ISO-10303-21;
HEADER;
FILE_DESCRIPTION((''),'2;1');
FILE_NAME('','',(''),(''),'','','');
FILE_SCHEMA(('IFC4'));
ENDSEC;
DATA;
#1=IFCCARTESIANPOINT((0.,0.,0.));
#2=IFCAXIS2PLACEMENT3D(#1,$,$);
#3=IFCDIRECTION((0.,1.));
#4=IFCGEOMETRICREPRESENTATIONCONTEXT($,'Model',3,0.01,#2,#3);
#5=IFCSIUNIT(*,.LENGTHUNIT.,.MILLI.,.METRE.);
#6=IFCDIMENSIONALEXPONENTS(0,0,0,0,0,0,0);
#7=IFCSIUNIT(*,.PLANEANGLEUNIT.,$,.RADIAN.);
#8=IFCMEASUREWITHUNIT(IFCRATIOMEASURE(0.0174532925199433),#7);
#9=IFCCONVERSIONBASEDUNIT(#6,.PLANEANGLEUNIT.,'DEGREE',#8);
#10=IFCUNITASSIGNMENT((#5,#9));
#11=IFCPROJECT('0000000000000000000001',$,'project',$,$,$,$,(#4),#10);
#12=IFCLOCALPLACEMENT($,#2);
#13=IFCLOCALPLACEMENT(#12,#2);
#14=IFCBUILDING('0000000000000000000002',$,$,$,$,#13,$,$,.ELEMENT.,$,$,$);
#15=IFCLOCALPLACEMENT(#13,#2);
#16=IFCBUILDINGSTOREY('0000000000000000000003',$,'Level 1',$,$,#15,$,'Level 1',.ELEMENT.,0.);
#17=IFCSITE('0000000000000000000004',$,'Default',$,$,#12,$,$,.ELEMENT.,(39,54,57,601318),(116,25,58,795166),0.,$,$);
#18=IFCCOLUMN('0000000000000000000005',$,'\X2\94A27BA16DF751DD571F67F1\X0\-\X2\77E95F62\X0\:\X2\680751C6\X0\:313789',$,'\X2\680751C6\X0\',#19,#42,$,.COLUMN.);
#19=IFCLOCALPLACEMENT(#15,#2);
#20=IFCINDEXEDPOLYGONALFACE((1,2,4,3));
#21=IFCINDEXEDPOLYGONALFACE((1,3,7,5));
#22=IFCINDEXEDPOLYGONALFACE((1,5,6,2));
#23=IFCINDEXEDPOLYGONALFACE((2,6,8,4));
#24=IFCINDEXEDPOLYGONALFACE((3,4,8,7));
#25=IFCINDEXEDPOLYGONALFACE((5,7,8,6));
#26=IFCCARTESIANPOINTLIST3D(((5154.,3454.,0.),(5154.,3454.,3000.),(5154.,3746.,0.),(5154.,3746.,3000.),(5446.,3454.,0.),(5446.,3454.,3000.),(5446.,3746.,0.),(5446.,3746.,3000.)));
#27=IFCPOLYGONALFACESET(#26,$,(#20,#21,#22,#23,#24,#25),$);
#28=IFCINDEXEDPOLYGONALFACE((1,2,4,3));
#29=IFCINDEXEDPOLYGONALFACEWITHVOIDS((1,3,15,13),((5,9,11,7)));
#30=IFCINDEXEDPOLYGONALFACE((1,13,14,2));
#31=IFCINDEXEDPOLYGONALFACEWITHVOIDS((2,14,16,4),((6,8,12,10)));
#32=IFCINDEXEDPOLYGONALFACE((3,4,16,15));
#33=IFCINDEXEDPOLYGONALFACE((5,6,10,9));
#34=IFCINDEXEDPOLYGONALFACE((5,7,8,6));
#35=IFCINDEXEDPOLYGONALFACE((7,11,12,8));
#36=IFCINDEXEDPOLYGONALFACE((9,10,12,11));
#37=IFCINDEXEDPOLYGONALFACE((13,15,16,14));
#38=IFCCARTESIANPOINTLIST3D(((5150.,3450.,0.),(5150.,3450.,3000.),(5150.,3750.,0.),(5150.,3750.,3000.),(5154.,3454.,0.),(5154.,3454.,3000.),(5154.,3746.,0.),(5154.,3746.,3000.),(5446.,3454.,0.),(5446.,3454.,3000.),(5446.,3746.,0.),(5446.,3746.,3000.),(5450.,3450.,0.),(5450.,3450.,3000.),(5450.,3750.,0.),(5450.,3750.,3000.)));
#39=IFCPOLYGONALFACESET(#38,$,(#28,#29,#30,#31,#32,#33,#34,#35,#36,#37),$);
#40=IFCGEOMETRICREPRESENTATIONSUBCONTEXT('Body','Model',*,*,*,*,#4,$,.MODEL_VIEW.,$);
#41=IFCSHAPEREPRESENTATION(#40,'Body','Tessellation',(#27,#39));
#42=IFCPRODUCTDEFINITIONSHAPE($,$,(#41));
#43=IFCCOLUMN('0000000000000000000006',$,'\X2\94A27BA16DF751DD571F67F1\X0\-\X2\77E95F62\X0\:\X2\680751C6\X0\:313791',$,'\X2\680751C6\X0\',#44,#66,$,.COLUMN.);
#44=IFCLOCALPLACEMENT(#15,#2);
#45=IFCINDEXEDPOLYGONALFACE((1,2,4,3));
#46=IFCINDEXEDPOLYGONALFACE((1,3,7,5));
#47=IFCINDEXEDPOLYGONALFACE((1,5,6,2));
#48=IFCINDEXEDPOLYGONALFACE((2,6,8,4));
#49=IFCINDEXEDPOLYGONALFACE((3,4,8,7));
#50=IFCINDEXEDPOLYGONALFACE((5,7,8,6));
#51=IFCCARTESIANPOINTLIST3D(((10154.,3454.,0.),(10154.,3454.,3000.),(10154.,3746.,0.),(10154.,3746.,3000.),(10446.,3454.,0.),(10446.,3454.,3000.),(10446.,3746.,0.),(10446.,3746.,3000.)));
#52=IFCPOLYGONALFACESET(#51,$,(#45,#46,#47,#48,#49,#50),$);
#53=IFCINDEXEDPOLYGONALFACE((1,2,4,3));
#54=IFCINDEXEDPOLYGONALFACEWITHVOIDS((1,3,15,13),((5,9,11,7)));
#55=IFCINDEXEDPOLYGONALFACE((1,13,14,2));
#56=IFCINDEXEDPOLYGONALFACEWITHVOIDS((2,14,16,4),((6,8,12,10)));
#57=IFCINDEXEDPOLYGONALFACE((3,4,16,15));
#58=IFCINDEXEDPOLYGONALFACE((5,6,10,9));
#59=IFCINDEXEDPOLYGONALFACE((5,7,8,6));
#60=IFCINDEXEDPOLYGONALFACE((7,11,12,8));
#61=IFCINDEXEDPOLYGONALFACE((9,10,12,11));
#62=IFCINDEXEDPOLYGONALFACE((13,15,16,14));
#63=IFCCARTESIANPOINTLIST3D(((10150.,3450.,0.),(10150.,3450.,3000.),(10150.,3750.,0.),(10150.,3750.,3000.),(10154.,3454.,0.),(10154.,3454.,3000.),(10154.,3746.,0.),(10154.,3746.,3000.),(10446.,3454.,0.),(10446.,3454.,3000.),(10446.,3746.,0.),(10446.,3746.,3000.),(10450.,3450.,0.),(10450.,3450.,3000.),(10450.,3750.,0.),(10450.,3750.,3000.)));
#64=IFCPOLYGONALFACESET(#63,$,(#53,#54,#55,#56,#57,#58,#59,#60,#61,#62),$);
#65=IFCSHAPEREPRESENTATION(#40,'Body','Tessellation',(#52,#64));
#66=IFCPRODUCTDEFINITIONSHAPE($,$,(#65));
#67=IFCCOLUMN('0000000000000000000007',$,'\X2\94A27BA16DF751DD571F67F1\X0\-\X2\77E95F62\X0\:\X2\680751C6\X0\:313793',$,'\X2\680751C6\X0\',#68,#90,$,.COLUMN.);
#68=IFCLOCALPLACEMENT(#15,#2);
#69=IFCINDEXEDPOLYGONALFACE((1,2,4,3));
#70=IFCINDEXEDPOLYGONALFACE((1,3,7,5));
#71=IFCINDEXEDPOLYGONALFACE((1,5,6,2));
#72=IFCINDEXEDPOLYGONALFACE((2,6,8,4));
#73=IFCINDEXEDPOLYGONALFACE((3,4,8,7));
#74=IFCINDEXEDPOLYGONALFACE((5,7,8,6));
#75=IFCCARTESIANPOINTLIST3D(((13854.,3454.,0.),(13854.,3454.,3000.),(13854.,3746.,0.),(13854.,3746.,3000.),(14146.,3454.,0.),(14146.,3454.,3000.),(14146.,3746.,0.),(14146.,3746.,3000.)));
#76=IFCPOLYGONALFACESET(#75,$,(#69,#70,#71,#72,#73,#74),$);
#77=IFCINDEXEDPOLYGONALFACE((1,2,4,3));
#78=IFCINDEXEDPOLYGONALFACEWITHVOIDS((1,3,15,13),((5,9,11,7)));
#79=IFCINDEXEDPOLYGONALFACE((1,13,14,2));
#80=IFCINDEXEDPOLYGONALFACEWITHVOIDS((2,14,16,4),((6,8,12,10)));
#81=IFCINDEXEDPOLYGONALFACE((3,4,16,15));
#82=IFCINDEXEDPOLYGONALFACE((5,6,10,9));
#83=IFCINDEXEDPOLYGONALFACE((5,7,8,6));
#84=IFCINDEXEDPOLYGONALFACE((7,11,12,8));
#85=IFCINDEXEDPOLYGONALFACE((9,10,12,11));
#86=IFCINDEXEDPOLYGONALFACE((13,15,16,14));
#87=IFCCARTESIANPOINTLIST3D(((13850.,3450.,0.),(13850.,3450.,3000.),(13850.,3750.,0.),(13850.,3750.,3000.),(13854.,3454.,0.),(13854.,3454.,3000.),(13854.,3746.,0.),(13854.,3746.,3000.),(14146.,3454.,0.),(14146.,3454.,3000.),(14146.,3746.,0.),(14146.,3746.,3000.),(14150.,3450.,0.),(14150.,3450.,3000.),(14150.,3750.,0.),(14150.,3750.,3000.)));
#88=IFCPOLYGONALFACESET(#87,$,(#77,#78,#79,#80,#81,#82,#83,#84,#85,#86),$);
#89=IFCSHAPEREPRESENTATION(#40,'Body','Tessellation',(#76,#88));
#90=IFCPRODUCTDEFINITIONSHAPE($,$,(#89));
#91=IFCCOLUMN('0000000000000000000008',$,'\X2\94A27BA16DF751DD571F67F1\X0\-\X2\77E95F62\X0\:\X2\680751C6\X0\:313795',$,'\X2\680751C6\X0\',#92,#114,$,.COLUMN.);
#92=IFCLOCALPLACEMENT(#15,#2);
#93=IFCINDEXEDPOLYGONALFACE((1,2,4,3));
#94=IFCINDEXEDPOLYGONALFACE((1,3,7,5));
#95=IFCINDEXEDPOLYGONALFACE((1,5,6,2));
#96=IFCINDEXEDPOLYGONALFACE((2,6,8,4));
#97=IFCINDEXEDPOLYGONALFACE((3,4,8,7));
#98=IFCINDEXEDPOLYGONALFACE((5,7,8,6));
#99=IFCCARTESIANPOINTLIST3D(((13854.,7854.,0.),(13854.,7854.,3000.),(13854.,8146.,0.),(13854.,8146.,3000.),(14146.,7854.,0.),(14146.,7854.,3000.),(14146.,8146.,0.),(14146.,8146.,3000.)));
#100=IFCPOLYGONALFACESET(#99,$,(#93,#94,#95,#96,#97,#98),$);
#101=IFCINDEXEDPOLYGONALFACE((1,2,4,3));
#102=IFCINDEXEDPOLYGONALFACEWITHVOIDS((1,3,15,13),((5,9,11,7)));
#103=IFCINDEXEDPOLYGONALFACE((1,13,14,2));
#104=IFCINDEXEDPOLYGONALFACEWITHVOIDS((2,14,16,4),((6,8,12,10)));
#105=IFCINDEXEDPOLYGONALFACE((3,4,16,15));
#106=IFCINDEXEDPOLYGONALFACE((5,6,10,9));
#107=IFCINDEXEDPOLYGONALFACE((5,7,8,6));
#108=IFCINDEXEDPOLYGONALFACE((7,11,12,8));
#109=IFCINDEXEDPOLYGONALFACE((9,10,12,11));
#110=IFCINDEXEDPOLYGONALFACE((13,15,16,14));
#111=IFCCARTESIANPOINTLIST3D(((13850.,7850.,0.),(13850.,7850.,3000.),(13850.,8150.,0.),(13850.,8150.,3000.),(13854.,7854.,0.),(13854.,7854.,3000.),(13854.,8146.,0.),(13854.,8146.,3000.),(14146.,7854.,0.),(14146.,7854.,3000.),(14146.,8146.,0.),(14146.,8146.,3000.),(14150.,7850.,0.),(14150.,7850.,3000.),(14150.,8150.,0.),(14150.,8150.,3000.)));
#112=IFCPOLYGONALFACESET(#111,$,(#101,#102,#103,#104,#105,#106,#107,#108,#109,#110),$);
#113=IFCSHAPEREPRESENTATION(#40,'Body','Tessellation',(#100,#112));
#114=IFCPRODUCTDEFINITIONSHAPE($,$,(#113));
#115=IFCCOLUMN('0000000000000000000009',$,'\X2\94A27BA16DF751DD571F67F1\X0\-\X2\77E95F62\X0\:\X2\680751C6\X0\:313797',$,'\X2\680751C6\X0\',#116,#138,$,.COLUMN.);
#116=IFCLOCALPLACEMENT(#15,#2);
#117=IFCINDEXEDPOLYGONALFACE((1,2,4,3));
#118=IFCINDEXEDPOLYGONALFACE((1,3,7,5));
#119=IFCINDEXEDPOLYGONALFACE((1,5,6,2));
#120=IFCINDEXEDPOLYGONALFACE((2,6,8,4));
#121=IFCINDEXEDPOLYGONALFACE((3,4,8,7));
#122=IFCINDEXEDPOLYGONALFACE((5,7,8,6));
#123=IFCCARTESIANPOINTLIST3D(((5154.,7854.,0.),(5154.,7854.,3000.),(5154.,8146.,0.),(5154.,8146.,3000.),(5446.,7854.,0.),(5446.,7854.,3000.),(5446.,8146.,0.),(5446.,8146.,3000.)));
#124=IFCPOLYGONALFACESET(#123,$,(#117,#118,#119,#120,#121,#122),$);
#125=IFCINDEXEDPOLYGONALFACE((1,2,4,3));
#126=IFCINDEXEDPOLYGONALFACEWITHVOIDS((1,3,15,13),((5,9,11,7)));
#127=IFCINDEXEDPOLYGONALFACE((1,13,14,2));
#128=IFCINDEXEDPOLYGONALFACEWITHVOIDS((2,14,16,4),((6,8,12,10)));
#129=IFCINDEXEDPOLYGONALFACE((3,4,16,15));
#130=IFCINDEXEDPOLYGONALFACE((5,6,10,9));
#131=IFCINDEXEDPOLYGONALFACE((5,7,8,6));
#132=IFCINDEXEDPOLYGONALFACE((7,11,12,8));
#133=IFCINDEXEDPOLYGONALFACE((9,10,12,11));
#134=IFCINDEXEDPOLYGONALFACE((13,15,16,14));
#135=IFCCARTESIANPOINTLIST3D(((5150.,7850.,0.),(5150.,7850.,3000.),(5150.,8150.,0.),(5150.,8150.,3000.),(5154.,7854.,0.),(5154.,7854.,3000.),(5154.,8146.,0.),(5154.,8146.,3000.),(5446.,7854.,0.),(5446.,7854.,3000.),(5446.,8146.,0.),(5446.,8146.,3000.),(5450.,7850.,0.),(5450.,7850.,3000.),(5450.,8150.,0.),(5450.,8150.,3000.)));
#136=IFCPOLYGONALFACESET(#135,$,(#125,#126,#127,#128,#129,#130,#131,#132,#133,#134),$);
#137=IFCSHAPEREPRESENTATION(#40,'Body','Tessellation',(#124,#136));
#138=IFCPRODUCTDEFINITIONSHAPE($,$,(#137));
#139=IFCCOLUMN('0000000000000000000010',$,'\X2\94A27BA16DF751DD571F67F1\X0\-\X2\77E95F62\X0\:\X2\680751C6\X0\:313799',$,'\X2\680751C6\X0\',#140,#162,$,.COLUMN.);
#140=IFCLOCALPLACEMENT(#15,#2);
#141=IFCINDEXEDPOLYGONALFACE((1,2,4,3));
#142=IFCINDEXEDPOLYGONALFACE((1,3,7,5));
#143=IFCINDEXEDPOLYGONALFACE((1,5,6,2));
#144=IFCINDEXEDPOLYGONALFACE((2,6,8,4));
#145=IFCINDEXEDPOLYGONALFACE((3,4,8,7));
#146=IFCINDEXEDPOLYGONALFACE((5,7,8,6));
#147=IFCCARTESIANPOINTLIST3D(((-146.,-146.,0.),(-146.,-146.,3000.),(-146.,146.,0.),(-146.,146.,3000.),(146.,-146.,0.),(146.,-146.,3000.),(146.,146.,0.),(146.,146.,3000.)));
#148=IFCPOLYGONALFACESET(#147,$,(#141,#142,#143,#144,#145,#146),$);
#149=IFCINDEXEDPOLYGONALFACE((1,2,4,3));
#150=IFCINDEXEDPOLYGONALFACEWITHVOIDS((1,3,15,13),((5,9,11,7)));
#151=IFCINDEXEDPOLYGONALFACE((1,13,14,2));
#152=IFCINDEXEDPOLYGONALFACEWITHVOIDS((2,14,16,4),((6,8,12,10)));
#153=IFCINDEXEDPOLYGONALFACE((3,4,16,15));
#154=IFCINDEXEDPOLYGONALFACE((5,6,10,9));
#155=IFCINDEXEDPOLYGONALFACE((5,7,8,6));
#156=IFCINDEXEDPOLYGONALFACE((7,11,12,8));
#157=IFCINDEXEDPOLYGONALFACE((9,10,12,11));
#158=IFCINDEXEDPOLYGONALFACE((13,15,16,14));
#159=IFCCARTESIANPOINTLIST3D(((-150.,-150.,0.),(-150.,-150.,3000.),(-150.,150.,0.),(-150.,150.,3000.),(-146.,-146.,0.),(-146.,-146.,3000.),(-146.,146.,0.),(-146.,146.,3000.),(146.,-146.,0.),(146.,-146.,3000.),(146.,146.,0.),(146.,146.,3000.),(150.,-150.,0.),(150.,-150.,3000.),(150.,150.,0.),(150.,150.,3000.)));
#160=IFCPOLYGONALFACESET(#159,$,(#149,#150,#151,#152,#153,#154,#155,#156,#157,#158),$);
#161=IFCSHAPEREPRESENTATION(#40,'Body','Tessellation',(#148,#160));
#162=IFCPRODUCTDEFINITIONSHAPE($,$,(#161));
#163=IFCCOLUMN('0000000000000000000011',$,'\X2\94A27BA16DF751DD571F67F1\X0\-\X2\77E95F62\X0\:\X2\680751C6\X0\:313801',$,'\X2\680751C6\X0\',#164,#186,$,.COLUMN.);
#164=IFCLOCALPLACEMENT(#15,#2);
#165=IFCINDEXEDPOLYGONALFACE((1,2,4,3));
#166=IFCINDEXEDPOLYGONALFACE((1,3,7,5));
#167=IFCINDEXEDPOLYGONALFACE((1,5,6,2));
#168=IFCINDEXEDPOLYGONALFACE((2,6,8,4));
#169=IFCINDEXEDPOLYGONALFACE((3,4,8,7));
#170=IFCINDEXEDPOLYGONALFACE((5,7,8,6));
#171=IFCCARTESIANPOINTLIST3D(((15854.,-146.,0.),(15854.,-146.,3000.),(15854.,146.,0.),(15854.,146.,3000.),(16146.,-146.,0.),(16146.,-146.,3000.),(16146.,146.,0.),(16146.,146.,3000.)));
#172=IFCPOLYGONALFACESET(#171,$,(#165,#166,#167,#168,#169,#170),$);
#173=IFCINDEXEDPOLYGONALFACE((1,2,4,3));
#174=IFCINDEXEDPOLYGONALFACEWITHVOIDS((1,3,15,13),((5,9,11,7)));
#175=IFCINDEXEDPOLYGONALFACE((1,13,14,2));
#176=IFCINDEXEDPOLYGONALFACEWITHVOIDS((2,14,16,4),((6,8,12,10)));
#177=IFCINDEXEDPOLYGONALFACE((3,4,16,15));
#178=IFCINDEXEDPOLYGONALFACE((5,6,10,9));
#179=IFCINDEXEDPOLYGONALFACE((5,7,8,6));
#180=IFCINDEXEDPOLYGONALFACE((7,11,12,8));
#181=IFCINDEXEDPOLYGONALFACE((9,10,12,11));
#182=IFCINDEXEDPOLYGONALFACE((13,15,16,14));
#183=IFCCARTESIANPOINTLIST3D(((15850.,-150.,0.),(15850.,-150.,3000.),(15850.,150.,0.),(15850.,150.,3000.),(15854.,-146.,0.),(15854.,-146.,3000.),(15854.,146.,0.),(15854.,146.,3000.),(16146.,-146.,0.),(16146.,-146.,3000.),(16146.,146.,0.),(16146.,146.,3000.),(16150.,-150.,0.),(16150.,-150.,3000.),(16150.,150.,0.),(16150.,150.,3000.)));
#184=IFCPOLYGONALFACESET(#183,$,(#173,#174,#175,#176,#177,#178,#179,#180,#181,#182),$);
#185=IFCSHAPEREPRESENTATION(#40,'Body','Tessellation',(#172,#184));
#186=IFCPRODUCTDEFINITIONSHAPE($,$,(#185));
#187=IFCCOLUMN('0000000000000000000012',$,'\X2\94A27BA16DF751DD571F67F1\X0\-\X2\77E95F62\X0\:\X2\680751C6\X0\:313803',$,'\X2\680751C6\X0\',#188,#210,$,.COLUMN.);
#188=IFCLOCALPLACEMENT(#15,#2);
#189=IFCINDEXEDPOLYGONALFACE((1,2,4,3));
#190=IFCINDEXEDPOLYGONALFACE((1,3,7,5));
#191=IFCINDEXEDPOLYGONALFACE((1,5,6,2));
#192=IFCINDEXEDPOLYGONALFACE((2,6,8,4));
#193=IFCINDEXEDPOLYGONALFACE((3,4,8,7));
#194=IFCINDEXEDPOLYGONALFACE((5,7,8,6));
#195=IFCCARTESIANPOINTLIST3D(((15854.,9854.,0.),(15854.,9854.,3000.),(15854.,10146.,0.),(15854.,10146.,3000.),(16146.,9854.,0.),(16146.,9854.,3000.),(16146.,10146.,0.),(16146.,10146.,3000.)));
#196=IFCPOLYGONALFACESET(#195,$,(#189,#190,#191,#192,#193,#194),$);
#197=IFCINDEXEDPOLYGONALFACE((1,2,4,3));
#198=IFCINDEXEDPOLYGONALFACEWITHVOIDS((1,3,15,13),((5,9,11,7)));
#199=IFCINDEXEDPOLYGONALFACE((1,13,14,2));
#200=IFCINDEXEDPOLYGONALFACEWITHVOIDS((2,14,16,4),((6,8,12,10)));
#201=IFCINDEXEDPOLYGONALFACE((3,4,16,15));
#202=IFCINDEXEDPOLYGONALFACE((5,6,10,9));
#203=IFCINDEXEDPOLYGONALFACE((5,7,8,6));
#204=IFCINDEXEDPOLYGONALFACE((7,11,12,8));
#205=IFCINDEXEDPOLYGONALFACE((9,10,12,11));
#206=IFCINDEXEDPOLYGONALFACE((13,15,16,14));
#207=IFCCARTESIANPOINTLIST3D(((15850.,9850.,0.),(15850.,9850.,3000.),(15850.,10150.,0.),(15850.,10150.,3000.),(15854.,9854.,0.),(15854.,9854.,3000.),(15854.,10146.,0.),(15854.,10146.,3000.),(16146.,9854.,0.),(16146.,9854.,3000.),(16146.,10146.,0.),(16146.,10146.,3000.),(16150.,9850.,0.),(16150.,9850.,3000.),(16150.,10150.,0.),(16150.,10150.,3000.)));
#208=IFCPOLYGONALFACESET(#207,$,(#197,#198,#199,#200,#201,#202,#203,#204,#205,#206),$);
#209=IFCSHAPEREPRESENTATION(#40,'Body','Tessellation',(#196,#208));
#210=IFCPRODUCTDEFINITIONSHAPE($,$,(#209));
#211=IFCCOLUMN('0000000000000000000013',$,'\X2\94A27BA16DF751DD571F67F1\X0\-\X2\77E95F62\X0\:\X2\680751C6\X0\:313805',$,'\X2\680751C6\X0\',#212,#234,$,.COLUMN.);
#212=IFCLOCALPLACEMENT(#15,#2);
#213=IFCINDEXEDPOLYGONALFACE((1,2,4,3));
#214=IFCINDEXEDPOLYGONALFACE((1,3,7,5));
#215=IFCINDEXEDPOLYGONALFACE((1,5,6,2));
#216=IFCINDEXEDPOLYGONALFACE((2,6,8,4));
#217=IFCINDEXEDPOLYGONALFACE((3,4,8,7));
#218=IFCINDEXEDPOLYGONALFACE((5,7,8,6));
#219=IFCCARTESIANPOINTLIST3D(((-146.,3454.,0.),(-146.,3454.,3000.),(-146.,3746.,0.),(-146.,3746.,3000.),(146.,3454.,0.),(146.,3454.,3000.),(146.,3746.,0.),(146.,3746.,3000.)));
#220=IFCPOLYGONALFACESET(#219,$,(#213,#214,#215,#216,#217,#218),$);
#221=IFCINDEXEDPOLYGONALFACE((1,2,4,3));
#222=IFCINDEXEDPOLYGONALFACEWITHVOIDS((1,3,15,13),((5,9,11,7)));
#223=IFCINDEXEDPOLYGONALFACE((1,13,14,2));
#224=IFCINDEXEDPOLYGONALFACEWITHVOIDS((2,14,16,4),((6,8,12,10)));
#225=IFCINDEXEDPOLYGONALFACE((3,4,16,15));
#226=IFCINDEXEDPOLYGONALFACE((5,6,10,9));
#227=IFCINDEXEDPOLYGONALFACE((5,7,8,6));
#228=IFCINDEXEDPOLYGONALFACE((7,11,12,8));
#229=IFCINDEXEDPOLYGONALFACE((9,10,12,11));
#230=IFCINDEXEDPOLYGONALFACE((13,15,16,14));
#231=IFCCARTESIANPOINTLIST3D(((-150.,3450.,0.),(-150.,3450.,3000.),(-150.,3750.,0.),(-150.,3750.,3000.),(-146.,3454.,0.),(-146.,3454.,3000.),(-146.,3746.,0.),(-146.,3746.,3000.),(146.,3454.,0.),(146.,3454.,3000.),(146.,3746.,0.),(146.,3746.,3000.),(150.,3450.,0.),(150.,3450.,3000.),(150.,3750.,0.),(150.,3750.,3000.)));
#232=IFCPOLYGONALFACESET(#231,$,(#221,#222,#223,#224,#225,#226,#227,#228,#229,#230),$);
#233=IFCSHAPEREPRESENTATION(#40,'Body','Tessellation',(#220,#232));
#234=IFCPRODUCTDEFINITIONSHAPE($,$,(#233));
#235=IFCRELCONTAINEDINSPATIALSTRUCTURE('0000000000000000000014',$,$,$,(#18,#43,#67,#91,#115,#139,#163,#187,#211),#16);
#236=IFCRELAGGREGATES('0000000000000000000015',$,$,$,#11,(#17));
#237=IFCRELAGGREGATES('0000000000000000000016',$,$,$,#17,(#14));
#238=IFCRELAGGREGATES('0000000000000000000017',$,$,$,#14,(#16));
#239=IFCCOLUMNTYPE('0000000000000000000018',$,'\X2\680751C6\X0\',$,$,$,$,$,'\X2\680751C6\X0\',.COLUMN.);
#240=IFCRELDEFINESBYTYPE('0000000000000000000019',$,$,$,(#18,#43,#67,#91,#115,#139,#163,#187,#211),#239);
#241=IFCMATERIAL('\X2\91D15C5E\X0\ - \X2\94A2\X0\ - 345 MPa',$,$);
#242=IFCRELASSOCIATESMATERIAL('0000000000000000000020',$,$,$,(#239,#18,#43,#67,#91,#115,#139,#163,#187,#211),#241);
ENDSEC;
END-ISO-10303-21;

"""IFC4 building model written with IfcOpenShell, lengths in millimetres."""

from ifc_helpers import new_model, entity, si_unit, converted_unit, direction, frame, origin, origin_2d_with_axis, place, context, subcontext, project, spatial, polyline, rectangle, outline, extrude, source, transform, mapped, material, type_object, type_shapes, element, save


model = new_model("IFC4")

# Units and contexts
model_context = context("Model", 3, precision=0.01, world=origin(), true_north=direction((0.0, 1.0)))
body_context = subcontext(model_context, "Body", "Model", "MODEL_VIEW")
ifc_project = project(units=[si_unit("LENGTHUNIT", "METRE", prefix="MILLI"), converted_unit("PLANEANGLEUNIT", "DEGREE", entity("IfcRatioMeasure", 0.0174532925199433), si_unit("PLANEANGLEUNIT", "RADIAN"), dimensions=[0, 0, 0, 0, 0, 0, 0])], contexts=[model_context])

# Site, building, storey
site_placement = place(None, origin())
site = spatial("IfcSite", under=ifc_project, at=site_placement, Name="Default", CompositionType="ELEMENT", RefLatitude=(39, 54, 57, 601318), RefLongitude=(116, 25, 58, 795166), RefElevation=0.0)
building_placement = place(site_placement, origin())
building = spatial("IfcBuilding", under=site, at=building_placement, CompositionType="ELEMENT")
storey_placement = place(building_placement, origin())
storey = spatial("IfcBuildingStorey", under=building, at=storey_placement, Name="Level 1", LongName="Level 1", CompositionType="ELEMENT", Elevation=0.0)

# Columns
ifc_material = material(Name="金属 - 钢 - 345 MPa")
column_type = type_object("IfcColumnType", Name="标准", ElementType="标准", PredefinedType="COLUMN", material=ifc_material)
shared_shape = source(origin(), body_context, "Body", "SweptSolid", [
    extrude(rectangle(XDim=292.0, YDim=292.0, at=origin_2d_with_axis()), frame((0.0, 0.0, 0.0), z_axis=(0.0, 0.0, 1.0), x_axis=(-1.0, 0.0, 0.0)), (0.0, 0.0, 1.0), 3000.0),
    extrude(outline(polyline([(-150.0, -150.0), (150.0, -150.0), (150.0, 150.0), (-150.0, 150.0), (-150.0, -150.0)]), holes=[polyline([(-146.0, -146.0), (-146.0, 146.0), (146.0, 146.0), (146.0, -146.0), (-146.0, -146.0)])]), frame((0.0, 0.0, 0.0), z_axis=(0.0, 0.0, 1.0), x_axis=(-1.0, 0.0, 0.0)), (0.0, 0.0, 1.0), 3000.0),
])
type_shapes(column_type, [shared_shape])
for number, where, name in (
    (1, (5300.0, 3600.0, 0.0), "钢管混凝土柱-矩形:标准:313789"),
    (2, (10300.0, 3600.0, 0.0), "钢管混凝土柱-矩形:标准:313791"),
    (3, (14000.0, 3600.0, 0.0), "钢管混凝土柱-矩形:标准:313793"),
    (4, (14000.0, 8000.0, 0.0), "钢管混凝土柱-矩形:标准:313795"),
    (5, (5300.0, 8000.0, 0.0), "钢管混凝土柱-矩形:标准:313797"),
    (6, (0.0, 0.0, 0.0), "钢管混凝土柱-矩形:标准:313799"),
    (7, (16000.0, 0.0, 0.0), "钢管混凝土柱-矩形:标准:313801"),
    (8, (16000.0, 10000.0, 0.0), "钢管混凝土柱-矩形:标准:313803"),
    (9, (0.0, 3600.0, 0.0), "钢管混凝土柱-矩形:标准:313805"),
):
    element("IfcColumn", number, at=place(storey_placement, frame(where)), inside=storey, type_object=column_type, material=ifc_material, Name=name, ObjectType="标准", PredefinedType="COLUMN", context=body_context, shape_type="MappedRepresentation", body=[
        mapped(shared_shape, transform((0.0, 0.0, 0.0), scale=1.0)),
    ])

save(model, "model.ifc")
